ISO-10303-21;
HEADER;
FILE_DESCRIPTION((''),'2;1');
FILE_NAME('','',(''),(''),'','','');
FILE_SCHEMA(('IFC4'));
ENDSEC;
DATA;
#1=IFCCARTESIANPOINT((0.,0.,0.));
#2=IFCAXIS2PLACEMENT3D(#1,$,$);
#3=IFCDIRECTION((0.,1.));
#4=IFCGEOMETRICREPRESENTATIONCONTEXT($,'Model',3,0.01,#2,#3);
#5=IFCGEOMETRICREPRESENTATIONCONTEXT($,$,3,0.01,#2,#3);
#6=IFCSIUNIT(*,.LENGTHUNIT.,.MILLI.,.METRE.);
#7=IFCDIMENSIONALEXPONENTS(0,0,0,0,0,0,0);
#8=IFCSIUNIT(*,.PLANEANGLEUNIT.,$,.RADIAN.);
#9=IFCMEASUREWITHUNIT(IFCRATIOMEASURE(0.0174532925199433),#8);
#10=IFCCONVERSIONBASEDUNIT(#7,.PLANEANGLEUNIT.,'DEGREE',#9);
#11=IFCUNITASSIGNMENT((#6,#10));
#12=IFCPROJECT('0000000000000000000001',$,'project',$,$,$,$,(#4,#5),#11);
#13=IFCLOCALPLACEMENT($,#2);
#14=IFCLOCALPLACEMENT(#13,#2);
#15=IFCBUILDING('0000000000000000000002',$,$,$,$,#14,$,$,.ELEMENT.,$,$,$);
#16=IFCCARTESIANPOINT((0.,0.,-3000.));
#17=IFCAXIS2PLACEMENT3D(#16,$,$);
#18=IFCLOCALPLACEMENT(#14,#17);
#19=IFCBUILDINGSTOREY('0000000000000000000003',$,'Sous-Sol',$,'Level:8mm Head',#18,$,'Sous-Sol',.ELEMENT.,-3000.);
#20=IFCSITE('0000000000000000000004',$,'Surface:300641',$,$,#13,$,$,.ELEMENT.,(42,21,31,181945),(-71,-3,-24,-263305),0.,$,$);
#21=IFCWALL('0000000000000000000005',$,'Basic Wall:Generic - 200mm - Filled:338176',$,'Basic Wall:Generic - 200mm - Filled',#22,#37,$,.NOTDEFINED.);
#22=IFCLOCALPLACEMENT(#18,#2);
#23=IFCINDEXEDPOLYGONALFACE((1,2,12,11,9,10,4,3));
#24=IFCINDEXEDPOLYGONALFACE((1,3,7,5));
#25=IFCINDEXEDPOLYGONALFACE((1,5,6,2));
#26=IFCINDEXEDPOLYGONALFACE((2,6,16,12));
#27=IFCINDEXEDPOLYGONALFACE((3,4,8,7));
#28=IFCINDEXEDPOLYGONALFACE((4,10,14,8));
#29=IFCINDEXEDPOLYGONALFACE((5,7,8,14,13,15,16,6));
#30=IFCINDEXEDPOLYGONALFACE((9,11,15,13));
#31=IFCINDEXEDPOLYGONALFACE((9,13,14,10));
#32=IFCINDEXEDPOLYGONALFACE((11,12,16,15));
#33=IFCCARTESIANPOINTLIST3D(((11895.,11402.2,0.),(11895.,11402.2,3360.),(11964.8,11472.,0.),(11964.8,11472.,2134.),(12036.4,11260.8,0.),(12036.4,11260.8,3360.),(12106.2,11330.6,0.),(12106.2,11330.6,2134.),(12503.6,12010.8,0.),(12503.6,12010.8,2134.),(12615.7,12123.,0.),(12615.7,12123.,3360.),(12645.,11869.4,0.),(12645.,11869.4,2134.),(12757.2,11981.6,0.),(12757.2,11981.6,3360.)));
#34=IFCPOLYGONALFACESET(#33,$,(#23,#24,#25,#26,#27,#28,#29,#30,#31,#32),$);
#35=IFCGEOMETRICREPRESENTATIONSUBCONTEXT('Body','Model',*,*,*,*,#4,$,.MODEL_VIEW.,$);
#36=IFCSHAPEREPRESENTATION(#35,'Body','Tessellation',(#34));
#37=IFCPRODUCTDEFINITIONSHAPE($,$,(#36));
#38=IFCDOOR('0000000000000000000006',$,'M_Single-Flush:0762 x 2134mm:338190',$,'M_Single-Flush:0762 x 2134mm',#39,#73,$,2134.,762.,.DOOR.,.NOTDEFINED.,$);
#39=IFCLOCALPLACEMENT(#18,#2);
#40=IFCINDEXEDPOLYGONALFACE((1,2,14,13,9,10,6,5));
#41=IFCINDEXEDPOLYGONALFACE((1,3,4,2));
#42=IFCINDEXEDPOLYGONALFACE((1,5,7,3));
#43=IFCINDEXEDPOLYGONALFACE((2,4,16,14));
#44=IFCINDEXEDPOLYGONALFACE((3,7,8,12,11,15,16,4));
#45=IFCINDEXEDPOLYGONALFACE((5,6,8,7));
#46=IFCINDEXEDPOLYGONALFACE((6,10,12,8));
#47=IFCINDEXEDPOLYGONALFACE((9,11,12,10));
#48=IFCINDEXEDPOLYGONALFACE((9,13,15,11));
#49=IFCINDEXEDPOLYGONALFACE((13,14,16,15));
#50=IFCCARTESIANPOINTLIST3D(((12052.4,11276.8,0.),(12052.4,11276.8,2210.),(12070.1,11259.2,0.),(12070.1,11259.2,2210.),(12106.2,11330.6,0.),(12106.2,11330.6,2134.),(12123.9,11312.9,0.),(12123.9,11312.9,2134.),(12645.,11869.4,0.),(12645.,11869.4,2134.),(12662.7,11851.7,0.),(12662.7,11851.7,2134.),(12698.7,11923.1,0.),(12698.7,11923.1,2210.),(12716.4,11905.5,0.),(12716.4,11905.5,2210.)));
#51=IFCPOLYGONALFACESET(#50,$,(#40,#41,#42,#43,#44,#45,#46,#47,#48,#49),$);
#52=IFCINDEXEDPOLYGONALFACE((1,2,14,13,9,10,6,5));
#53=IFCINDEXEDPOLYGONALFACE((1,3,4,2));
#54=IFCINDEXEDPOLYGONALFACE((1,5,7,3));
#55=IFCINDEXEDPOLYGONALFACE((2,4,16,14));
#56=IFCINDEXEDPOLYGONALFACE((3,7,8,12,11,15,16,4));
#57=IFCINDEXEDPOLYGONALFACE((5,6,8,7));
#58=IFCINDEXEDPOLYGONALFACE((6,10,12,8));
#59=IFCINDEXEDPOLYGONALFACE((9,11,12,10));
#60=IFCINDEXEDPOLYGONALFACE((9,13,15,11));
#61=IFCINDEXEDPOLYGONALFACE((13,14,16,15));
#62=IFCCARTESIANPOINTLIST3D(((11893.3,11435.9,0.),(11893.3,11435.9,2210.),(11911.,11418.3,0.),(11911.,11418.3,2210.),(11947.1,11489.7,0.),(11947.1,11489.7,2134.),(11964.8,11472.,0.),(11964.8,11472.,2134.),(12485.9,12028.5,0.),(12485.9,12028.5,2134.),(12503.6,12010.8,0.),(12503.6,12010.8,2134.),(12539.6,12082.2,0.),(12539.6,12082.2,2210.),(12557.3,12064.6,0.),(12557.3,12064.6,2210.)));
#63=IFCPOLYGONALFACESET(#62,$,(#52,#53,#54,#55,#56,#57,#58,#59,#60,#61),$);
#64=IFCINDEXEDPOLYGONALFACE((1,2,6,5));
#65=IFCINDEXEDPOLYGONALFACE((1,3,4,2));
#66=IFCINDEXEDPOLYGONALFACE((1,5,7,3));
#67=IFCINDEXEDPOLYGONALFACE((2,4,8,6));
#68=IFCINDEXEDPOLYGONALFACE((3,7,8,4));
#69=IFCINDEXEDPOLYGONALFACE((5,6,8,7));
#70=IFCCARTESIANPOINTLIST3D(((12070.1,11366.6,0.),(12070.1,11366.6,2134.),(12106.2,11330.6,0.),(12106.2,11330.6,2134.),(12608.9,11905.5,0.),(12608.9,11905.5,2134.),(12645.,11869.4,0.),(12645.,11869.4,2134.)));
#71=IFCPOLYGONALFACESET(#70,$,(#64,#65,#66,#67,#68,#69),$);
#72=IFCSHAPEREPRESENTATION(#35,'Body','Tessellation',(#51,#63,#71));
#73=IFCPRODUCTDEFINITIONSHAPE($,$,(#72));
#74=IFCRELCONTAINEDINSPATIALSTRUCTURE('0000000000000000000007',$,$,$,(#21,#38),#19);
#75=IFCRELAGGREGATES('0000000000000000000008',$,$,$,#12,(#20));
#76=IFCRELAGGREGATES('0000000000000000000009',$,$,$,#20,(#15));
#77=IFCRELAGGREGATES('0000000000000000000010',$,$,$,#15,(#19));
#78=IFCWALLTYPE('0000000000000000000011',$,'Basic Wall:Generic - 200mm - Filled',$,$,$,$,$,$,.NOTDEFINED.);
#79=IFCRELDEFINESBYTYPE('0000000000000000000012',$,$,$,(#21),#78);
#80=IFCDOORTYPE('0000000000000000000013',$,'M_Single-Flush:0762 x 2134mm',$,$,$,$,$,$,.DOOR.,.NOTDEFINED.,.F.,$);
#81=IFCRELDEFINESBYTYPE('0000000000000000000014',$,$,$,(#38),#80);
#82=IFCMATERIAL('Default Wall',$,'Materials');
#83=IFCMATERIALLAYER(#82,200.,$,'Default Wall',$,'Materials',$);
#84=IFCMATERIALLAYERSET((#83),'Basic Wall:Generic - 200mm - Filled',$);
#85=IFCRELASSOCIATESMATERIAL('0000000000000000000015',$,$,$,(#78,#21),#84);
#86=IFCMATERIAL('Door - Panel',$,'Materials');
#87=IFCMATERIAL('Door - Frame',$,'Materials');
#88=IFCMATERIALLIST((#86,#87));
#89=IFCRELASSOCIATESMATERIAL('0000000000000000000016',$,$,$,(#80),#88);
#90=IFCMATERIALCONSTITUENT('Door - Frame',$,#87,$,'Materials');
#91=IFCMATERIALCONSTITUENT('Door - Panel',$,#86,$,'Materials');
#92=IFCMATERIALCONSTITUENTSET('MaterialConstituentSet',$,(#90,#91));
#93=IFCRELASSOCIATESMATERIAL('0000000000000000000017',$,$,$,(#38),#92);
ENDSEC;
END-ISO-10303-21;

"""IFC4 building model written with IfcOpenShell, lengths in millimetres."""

from ifc_helpers import new_model, entity, si_unit, converted_unit, direction, frame, frame_2d, origin, place, context, subcontext, project, spatial, polyline, rectangle, outline, extrude, clip, bounded_halfspace, source, transform, mapped, material, material_list, layer, layer_set, layer_usage, constituent, constituent_set, type_object, type_shapes, element, fill, save


model = new_model("IFC4")

# Units and contexts
model_context = context("Model", 3, precision=0.01, world=origin(), true_north=direction((0.0, 1.0)))
context_of_model = context(None, 3, precision=0.01, world=origin(), true_north=direction((0.0, 1.0)))
body_context = subcontext(model_context, "Body", "Model", "MODEL_VIEW")
ifc_project = project(units=[si_unit("LENGTHUNIT", "METRE", prefix="MILLI"), converted_unit("PLANEANGLEUNIT", "DEGREE", entity("IfcRatioMeasure", 0.0174532925199433), si_unit("PLANEANGLEUNIT", "RADIAN"), dimensions=[0, 0, 0, 0, 0, 0, 0])], contexts=[model_context, context_of_model])

# Site, building, storey
site_placement = place(None, origin())
site = spatial("IfcSite", under=ifc_project, at=site_placement, Name="Surface:300641", CompositionType="ELEMENT", RefLatitude=(42, 21, 31, 181945), RefLongitude=(-71, -3, -24, -263305), RefElevation=0.0)
building_placement = place(site_placement, origin())
building = spatial("IfcBuilding", under=site, at=building_placement, CompositionType="ELEMENT")
storey_placement = place(building_placement, frame((0.0, 0.0, -3000.0)))
storey = spatial("IfcBuildingStorey", under=building, at=storey_placement, Name="Sous-Sol", ObjectType="Level:8mm Head", LongName="Sous-Sol", CompositionType="ELEMENT", Elevation=-3000.0)

# Shared definitions
ifc_material_1 = material(Name="Default Wall", Category="Materials")

# Shared definitions
ifc_layer_1 = layer(ifc_material_1, 200.0, Name="Default Wall", Category="Materials")
ifc_layer_set_1 = layer_set([ifc_layer_1], Name="Basic Wall:Generic - 200mm - Filled")
wall_type_1 = type_object("IfcWallType", Name="Basic Wall:Generic - 200mm - Filled", PredefinedType="NOTDEFINED", material=ifc_layer_set_1)

# Wall, opening, door
ifc_layer_usage_1 = layer_usage(ifc_layer_set_1, "AXIS2", "NEGATIVE", 100.0)
wall_1_placement = place(storey_placement, frame((11965.7, 11331.5, 0.0), z_axis=(0.0, 0.0, 1.0), x_axis=(0.707107, 0.707107, 0.0)))
wall_1 = element("IfcWall", 1, at=wall_1_placement, inside=storey, type_object=wall_type_1, material=ifc_layer_usage_1, Name="Basic Wall:Generic - 200mm - Filled:338176", ObjectType="Basic Wall:Generic - 200mm - Filled", PredefinedType="NOTDEFINED", context=body_context, shape_type="Clipping", body=[
    clip(extrude(rectangle(XDim=1019.3, YDim=200.0, at=frame_2d((509.6, 0.0), x_axis=(-1.0, 0.0))), origin(), (0.0, 0.0, 1.0), 3360.0), bounded_halfspace(frame((0.0, -100.0, 3360.0), z_axis=(0.0, 0.0, -1.0), x_axis=(-0.707107, -0.707107, 0.0)), True, frame((0.0, -100.0, 3360.0)), polyline([(0.0, 0.0), (1019.3, 0.0), (1019.3, 200.0), (0.0, 200.0), (0.0, 0.0)]))),
])
opening_1_placement = place(wall_1_placement, frame((860.6, 100.0, 0.0)))
opening_1 = element("IfcOpeningElement", 2, at=opening_1_placement, cuts=wall_1, ObjectType="Opening", PredefinedType="OPENING", context=body_context, shape_type="SweptSolid", body=[
    extrude(rectangle(XDim=762.0, YDim=2134.0, at=frame_2d((1067.0, 381.0), x_axis=(0.0, 1.0))), frame((0.0, 0.0, 0.0), z_axis=(0.0, -1.0, 0.0), x_axis=(0.0, 0.0, 1.0)), (0.0, 0.0, 1.0), 200.0),
])
ifc_material_2 = material(Name="Door - Frame", Category="Materials")
ifc_constituent_1 = constituent(ifc_material_2, Name="Door - Frame", Category="Materials")
ifc_material_3 = material(Name="Door - Panel", Category="Materials")
ifc_constituent_2 = constituent(ifc_material_3, Name="Door - Panel", Category="Materials")
ifc_constituent_set_1 = constituent_set(constituents=[ifc_constituent_1, ifc_constituent_2], Name="MaterialConstituentSet")
ifc_material_list_1 = material_list([ifc_material_3, ifc_material_2])
door_type = type_object("IfcDoorType", Name="M_Single-Flush:0762 x 2134mm", OperationType="NOTDEFINED", ParameterTakesPrecedence=False, PredefinedType="DOOR", material=ifc_material_list_1)
shared_shape_1 = source(origin(), body_context, "Body", "SweptSolid", [
    extrude(outline(polyline([(-457.0, -1124.0), (457.0, -1124.0), (457.0, 1086.0), (381.0, 1086.0), (381.0, -1048.0), (-381.0, -1048.0), (-381.0, 1086.0), (-457.0, 1086.0), (-457.0, -1124.0)])), frame((381.0, 200.0, 1086.0), z_axis=(0.0, 1.0, 0.0), x_axis=(1.0, 0.0, 0.0)), (0.0, 0.0, 1.0), 25.0),
    extrude(outline(polyline([(-1124.0, -457.0), (1086.0, -457.0), (1086.0, -381.0), (-1048.0, -381.0), (-1048.0, 381.0), (1086.0, 381.0), (1086.0, 457.0), (-1124.0, 457.0), (-1124.0, -457.0)])), frame((381.0, -25.0, 1086.0), z_axis=(0.0, 1.0, 0.0), x_axis=(0.0, 0.0, -1.0)), (0.0, 0.0, 1.0), 25.0),
    extrude(rectangle(XDim=51.0, YDim=762.0, at=frame_2d((0.0, 0.0), x_axis=(1.0, 0.0))), frame((381.0, 174.5, 0.0), z_axis=(0.0, 0.0, 1.0), x_axis=(0.0, 1.0, 0.0)), (0.0, 0.0, 1.0), 2134.0),
])
type_shapes(door_type, [shared_shape_1])
door_placement = place(opening_1_placement, frame((0.0, 0.0, 0.0), z_axis=(0.0, 0.0, 1.0), x_axis=(-1.0, 0.0, 0.0)))
door = element("IfcDoor", 3, at=door_placement, inside=storey, type_object=door_type, material=ifc_constituent_set_1, Name="M_Single-Flush:0762 x 2134mm:338190", ObjectType="M_Single-Flush:0762 x 2134mm", OperationType="NOTDEFINED", OverallHeight=2134.0, OverallWidth=762.0, PredefinedType="DOOR", context=body_context, shape_type="MappedRepresentation", body=[
    mapped(shared_shape_1, transform((0.0, 0.0, 0.0), scale=1.0)),
])
fill(opening_1, door)

save(model, "model.ifc")
